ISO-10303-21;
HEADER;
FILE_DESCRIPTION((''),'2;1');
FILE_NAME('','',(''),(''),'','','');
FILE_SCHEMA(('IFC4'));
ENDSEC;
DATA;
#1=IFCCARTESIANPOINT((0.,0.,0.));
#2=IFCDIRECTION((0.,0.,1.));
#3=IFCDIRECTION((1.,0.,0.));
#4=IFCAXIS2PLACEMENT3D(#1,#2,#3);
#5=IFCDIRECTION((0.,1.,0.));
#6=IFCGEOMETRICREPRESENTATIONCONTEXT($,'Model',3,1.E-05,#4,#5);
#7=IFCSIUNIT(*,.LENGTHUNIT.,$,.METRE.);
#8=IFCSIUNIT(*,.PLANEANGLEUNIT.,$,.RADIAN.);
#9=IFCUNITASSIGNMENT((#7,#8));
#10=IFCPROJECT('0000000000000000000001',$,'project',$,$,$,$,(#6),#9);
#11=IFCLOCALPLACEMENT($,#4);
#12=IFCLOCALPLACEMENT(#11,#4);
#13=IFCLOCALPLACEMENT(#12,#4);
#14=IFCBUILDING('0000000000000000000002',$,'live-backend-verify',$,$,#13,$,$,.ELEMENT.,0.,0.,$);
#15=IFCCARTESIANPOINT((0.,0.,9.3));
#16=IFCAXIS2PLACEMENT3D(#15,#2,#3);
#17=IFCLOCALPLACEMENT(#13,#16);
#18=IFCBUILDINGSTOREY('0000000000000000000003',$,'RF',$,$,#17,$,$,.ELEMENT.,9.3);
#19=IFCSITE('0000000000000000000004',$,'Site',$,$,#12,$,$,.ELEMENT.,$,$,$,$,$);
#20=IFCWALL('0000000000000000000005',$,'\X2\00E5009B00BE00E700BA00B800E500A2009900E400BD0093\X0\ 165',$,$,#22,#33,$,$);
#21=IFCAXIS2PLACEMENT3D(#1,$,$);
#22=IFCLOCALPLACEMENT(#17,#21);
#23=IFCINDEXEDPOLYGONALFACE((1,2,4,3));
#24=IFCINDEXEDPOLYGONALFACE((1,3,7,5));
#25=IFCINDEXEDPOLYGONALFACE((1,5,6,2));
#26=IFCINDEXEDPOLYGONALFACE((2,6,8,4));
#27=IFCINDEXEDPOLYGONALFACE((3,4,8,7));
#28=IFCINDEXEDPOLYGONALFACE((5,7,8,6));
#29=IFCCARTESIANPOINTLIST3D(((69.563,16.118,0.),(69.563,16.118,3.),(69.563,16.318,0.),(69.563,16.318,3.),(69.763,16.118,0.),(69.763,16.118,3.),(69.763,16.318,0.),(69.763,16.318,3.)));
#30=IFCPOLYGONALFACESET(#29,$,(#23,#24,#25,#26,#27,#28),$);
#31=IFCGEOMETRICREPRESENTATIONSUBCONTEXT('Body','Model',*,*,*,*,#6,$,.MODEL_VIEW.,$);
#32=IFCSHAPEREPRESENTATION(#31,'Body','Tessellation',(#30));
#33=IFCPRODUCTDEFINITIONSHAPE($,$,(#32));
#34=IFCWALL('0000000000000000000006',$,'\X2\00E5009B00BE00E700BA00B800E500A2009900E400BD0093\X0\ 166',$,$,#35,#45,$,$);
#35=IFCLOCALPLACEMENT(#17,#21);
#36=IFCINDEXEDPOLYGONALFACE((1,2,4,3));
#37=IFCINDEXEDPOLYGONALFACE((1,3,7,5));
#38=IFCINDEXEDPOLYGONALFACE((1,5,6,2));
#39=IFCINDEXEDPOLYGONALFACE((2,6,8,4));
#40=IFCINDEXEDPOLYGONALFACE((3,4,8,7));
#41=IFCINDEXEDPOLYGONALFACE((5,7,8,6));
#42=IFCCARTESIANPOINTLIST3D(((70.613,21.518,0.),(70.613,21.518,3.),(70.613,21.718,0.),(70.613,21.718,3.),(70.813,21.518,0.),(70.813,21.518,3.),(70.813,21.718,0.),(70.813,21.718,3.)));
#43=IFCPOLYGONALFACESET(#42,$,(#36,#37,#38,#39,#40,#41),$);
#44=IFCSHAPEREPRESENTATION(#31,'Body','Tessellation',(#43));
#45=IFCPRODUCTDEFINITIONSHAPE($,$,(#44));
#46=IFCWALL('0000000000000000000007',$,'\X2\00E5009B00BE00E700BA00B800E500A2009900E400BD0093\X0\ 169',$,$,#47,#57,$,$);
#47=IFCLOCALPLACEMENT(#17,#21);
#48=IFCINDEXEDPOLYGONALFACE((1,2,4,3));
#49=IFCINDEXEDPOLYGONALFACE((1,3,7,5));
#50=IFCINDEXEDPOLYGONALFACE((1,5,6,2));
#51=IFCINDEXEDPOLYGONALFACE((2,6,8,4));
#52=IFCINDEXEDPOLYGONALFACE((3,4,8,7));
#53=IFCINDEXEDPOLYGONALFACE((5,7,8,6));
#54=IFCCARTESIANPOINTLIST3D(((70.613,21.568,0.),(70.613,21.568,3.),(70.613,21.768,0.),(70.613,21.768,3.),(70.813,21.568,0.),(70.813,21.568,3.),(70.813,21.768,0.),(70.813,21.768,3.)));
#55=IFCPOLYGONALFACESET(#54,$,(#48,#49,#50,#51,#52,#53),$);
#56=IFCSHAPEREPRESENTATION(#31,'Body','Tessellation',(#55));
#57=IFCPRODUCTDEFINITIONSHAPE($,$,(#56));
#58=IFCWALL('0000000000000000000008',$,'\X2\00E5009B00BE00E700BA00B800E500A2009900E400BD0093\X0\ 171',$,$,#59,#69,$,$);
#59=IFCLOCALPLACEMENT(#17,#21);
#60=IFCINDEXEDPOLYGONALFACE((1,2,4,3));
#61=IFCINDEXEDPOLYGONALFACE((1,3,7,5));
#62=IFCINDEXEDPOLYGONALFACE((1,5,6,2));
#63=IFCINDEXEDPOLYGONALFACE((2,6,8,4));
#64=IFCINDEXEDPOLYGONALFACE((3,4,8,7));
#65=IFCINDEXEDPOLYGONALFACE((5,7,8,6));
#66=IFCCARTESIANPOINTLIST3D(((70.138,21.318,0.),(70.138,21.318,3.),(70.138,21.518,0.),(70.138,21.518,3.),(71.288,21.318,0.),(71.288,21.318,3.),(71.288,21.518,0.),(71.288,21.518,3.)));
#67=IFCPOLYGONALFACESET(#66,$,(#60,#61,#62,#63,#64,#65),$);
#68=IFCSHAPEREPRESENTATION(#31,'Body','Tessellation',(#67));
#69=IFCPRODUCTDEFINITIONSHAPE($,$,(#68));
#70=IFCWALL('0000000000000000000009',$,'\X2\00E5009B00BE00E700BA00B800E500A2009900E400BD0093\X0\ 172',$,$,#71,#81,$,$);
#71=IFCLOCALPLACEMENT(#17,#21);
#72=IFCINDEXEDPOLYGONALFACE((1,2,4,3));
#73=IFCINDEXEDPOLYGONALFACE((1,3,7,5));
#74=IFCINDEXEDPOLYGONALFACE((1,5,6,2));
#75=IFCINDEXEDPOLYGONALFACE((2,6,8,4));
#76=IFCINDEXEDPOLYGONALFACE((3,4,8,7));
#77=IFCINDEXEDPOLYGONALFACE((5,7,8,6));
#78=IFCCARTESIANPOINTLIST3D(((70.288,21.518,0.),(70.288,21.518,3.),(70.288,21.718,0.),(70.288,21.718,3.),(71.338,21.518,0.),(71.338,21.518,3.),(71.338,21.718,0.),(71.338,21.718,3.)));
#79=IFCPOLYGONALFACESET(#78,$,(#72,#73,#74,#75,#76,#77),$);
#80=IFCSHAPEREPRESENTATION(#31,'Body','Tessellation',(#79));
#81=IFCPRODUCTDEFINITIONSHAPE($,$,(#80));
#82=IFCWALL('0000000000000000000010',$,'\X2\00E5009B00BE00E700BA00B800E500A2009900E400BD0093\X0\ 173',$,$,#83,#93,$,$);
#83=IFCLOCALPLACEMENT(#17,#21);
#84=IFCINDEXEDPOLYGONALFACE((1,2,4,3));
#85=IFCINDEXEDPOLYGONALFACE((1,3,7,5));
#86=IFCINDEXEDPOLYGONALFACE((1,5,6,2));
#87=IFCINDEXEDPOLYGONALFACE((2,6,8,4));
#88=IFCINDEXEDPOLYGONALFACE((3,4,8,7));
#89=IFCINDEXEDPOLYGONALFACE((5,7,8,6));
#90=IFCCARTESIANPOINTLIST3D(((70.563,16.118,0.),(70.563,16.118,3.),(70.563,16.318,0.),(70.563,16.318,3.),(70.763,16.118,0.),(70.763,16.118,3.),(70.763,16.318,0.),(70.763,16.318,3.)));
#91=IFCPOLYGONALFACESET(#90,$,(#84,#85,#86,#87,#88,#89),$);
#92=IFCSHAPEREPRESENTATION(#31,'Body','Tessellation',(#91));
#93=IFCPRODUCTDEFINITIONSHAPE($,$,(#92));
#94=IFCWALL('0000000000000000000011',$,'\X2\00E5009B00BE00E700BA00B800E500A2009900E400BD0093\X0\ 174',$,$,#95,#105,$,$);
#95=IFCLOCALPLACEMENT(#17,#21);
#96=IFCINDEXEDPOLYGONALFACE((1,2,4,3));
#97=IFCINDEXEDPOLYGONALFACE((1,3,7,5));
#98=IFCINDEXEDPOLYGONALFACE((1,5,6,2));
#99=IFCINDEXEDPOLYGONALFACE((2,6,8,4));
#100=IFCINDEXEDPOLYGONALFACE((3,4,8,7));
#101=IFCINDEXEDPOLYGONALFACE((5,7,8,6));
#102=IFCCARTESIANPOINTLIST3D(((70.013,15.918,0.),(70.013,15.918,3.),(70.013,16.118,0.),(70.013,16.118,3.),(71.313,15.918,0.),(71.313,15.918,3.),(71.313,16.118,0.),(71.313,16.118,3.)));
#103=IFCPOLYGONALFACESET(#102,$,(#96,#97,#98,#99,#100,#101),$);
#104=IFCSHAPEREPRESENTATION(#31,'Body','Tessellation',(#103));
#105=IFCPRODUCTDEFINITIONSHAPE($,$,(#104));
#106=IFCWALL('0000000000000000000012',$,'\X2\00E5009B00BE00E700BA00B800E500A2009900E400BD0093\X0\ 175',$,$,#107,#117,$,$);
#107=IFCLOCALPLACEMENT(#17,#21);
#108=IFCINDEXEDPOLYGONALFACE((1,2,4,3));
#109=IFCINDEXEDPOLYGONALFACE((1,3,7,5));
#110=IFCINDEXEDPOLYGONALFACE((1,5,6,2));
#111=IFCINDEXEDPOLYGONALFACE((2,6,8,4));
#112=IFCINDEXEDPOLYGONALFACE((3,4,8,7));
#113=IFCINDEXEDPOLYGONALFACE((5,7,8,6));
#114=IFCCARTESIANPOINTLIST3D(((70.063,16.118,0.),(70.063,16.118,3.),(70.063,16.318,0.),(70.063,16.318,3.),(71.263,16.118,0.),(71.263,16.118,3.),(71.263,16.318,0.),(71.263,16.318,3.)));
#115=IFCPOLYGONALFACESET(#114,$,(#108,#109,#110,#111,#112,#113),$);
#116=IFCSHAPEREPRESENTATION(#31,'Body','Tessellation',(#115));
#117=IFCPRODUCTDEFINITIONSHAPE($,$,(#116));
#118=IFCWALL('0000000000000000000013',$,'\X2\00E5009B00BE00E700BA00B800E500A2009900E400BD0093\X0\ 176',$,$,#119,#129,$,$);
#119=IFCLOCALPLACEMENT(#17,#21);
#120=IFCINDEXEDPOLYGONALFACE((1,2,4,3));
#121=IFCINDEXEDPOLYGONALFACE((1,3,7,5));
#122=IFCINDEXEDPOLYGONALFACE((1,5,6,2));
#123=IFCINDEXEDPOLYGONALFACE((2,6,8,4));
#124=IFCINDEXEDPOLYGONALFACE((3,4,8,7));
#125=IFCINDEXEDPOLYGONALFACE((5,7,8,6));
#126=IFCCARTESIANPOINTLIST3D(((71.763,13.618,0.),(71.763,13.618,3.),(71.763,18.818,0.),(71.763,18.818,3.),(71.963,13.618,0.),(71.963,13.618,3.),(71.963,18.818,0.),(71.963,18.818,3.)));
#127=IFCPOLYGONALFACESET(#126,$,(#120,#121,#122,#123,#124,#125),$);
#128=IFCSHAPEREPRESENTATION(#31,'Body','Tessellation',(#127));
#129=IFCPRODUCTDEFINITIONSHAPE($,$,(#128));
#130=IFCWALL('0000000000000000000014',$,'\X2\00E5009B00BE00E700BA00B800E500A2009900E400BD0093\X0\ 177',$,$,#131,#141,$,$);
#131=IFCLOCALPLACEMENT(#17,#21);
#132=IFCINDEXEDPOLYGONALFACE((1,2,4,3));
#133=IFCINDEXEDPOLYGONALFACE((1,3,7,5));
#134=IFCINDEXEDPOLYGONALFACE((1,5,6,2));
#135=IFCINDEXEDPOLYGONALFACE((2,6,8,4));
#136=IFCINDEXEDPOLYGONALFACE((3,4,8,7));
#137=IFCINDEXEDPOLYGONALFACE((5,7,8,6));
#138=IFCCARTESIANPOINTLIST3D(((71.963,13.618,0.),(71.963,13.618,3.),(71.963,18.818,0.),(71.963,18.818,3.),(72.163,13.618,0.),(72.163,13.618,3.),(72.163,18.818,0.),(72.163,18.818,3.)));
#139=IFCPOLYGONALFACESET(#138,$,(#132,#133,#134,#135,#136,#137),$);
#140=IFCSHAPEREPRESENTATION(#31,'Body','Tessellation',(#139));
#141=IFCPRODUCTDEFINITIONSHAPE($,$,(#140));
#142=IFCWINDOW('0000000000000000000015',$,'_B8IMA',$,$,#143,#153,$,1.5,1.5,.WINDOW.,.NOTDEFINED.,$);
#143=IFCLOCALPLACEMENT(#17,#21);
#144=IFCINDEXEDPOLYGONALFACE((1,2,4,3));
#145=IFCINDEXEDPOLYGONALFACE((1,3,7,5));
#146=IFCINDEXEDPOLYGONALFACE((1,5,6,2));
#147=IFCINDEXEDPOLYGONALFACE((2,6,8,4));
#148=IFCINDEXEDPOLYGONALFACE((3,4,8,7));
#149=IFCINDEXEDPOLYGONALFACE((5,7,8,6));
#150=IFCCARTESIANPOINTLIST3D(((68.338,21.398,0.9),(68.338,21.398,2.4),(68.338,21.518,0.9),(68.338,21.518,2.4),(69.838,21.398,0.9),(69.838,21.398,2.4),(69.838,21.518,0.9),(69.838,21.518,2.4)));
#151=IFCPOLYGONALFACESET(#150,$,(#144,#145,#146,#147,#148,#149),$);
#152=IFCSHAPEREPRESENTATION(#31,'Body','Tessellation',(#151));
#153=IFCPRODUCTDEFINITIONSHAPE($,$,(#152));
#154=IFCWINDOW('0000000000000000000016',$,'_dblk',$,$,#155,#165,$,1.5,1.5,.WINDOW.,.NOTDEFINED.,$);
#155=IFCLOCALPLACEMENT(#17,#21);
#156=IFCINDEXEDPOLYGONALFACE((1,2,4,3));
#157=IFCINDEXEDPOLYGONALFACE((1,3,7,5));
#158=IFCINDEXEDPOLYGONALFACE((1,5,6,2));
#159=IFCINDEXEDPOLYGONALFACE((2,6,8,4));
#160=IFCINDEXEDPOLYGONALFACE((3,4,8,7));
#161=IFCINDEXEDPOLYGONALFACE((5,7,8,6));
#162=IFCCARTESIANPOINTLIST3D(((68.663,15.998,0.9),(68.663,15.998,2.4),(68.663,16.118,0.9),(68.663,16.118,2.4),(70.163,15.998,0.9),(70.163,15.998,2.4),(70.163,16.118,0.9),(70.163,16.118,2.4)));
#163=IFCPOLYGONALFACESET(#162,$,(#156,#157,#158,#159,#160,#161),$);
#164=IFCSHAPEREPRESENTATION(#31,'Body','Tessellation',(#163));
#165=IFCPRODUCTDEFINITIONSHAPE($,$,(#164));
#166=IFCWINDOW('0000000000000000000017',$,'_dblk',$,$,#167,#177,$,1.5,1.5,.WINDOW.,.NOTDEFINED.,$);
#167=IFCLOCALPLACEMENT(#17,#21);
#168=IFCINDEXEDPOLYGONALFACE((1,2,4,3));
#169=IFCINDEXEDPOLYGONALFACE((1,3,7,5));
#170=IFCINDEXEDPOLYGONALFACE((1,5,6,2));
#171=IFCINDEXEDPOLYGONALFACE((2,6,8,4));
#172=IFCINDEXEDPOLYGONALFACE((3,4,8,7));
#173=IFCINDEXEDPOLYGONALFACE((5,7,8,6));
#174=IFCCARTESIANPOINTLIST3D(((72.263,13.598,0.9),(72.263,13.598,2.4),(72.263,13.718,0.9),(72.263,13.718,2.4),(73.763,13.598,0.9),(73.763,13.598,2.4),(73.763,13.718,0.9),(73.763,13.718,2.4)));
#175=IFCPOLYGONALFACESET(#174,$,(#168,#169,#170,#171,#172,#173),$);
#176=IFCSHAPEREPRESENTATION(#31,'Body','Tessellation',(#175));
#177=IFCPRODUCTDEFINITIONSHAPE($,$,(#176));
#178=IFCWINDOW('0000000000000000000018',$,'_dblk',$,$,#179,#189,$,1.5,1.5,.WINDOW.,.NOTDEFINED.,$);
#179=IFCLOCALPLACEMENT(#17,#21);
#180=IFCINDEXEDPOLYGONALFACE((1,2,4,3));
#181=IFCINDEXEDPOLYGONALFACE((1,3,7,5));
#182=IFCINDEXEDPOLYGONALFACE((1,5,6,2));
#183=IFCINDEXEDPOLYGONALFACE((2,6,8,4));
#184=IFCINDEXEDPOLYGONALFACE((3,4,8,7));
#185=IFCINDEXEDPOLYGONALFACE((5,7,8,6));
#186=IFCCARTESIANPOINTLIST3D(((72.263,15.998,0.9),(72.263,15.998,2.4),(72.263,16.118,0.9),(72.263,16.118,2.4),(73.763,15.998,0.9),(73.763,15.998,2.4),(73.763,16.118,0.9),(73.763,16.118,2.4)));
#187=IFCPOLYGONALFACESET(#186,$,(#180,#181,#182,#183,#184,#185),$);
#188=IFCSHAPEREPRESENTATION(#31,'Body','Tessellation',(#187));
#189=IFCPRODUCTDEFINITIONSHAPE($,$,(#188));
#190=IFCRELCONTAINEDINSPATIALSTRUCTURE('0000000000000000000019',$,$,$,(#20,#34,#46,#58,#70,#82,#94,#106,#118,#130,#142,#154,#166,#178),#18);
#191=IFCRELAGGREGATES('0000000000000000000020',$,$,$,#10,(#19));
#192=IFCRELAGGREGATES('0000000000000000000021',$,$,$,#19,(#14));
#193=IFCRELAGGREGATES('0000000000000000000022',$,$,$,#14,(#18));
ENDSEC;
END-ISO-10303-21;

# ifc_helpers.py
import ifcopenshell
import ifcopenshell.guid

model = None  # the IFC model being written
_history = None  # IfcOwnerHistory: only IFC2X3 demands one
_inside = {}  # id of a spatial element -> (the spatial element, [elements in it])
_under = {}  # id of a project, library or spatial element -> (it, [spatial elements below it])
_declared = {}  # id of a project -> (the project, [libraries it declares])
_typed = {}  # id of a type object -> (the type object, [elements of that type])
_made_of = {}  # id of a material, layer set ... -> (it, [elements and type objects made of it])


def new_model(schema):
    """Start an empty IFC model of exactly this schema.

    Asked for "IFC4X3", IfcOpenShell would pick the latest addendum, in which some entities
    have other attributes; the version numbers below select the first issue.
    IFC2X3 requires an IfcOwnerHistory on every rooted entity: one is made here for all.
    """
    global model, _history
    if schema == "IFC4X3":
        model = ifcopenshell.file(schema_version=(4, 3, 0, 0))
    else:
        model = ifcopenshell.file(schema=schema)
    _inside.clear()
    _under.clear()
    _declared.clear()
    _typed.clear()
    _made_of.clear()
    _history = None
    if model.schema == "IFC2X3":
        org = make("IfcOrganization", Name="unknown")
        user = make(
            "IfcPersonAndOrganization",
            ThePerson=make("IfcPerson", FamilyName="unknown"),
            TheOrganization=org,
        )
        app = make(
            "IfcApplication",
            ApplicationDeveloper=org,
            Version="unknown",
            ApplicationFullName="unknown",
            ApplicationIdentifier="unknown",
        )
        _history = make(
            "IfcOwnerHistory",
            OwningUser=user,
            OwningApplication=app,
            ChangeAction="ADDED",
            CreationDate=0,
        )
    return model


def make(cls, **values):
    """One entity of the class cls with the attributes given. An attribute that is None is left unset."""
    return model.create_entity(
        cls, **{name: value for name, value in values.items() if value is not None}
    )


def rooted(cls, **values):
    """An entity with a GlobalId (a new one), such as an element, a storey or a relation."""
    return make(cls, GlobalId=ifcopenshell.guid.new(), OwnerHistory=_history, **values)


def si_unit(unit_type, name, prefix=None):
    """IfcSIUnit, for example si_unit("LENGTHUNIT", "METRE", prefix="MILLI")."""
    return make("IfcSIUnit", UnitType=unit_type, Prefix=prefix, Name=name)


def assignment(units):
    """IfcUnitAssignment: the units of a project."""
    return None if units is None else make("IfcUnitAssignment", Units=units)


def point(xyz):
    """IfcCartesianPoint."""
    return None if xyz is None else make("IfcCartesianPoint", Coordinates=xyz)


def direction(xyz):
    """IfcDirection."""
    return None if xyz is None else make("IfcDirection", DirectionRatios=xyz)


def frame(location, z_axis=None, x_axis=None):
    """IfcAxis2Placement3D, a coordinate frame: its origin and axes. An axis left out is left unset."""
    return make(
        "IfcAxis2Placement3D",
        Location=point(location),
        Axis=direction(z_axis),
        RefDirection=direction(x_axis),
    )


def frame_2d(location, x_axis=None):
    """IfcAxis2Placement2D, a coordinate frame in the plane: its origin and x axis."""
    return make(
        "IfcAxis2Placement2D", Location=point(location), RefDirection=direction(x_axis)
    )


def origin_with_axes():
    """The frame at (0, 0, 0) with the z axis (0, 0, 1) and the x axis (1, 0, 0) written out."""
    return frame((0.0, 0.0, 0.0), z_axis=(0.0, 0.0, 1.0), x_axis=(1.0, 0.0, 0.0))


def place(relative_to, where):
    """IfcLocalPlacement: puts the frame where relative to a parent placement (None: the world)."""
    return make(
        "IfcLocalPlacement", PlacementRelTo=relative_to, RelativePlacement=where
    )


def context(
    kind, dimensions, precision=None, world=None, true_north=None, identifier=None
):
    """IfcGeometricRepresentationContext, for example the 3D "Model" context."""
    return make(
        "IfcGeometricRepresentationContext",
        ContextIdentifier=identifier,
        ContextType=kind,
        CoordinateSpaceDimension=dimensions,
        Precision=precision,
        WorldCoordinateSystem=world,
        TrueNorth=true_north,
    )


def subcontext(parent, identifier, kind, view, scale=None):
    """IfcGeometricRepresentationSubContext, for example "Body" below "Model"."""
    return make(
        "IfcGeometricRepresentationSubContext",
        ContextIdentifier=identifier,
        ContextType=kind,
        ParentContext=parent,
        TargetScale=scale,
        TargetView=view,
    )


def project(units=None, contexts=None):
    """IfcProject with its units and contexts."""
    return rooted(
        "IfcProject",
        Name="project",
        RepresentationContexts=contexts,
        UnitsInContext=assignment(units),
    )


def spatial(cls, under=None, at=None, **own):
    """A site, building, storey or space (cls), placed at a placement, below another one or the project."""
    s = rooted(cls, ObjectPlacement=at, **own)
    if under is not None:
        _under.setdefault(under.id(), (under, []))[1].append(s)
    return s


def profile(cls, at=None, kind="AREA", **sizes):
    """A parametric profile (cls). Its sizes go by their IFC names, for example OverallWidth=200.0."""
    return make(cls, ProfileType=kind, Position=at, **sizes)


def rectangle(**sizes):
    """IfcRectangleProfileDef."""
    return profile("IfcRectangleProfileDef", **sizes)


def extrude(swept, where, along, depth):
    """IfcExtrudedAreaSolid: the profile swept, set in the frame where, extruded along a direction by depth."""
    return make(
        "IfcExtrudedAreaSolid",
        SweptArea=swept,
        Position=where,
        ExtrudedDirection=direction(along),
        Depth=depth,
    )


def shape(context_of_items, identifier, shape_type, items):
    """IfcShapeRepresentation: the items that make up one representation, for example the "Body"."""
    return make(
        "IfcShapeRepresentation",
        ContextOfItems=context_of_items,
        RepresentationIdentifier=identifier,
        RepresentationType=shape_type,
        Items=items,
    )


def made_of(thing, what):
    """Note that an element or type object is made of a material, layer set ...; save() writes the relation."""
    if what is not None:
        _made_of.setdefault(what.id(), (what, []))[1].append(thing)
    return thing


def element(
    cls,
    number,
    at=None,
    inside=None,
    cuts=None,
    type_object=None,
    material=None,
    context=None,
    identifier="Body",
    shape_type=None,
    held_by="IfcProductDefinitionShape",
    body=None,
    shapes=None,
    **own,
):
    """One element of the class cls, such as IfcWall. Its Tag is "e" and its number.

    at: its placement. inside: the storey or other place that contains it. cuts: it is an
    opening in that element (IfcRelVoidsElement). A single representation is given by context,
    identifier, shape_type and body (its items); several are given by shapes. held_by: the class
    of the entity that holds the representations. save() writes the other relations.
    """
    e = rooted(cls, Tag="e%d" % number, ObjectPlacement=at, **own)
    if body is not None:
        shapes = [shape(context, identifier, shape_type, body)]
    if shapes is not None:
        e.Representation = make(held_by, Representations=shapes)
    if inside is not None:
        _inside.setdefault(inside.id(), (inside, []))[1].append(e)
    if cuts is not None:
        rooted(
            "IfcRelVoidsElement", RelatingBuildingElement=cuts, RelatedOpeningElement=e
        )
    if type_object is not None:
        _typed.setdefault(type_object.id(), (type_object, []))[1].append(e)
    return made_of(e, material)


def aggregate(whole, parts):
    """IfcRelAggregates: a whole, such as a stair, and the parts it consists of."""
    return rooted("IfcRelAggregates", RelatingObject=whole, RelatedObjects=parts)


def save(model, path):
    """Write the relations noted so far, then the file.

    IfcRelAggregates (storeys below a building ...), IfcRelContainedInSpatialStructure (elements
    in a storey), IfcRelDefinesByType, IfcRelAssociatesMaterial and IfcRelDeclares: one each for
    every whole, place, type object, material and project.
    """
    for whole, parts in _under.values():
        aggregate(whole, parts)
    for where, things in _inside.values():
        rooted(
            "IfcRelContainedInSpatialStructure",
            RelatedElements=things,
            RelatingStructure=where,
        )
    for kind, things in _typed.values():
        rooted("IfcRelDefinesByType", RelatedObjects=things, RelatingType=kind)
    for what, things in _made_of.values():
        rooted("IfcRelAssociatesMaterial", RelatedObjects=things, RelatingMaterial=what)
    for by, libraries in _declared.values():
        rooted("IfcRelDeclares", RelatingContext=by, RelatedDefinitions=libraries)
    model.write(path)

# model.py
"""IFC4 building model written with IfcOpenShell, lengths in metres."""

from ifc_helpers import new_model, si_unit, direction, frame, frame_2d, origin_with_axes, place, context, subcontext, project, spatial, rectangle, extrude, element, save


model = new_model("IFC4")

# Units and contexts
model_context = context("Model", 3, precision=1e-05, world=origin_with_axes(), true_north=direction((0.0, 1.0, 0.0)))
body_context = subcontext(model_context, "Body", "Model", "MODEL_VIEW")
ifc_project = project(units=[si_unit("LENGTHUNIT", "METRE"), si_unit("PLANEANGLEUNIT", "RADIAN")], contexts=[model_context])

# Site, building, storey
placement = place(None, origin_with_axes())
site_placement = place(placement, origin_with_axes())
site = spatial("IfcSite", under=ifc_project, at=site_placement, Name="Site", CompositionType="ELEMENT")
building_placement = place(site_placement, origin_with_axes())
building = spatial("IfcBuilding", under=site, at=building_placement, Name="live-backend-verify", CompositionType="ELEMENT", ElevationOfRefHeight=0.0, ElevationOfTerrain=0.0)
storey_placement = place(building_placement, frame((0.0, 0.0, 9.3), z_axis=(0.0, 0.0, 1.0), x_axis=(1.0, 0.0, 0.0)))
storey = spatial("IfcBuildingStorey", under=building, at=storey_placement, Name="RF", CompositionType="ELEMENT", Elevation=9.3)

# Walls
for number, where, z_axis, x_axis, name in (
    (1, (69.663, 16.218, 0.0), (0.0, 0.0, 1.0), (0.0, -1.0, 0.0), "å\u009b¾çº¸å¢\u0099ä½\u0093 165"),
    (2, (70.713, 21.618, 0.0), (0.0, 0.0, 1.0), (0.0, -1.0, 0.0), "å\u009b¾çº¸å¢\u0099ä½\u0093 166"),
    (3, (70.713, 21.668, 0.0), (0.0, 0.0, 1.0), (0.0, -1.0, 0.0), "å\u009b¾çº¸å¢\u0099ä½\u0093 169"),
):
    element("IfcWall", number, at=place(storey_placement, frame(where, z_axis=z_axis, x_axis=x_axis)), inside=storey, Name=name, context=body_context, shape_type="SweptSolid", body=[
        extrude(rectangle(XDim=0.2, YDim=0.2, at=frame_2d((0.0, 0.0), x_axis=(1.0, 0.0, 0.0))), frame((0.0, 0.0, 0.0), z_axis=(0.0, 0.0, 1.0)), (0.0, 0.0, 1.0), 3.0),
    ])
wall_1_placement = place(storey_placement, frame((70.713, 21.418, 0.0), z_axis=(0.0, 0.0, 1.0), x_axis=(1.0, 0.0, 0.0)))
element("IfcWall", 4, at=wall_1_placement, inside=storey, Name="å\u009b¾çº¸å¢\u0099ä½\u0093 171", context=body_context, shape_type="SweptSolid", body=[
    extrude(rectangle(XDim=1.15, YDim=0.2, at=frame_2d((0.0, 0.0), x_axis=(1.0, 0.0, 0.0))), frame((0.0, 0.0, 0.0), z_axis=(0.0, 0.0, 1.0)), (0.0, 0.0, 1.0), 3.0),
])
wall_2_placement = place(storey_placement, frame((70.813, 21.618, 0.0), z_axis=(0.0, 0.0, 1.0), x_axis=(1.0, 0.0, 0.0)))
element("IfcWall", 5, at=wall_2_placement, inside=storey, Name="å\u009b¾çº¸å¢\u0099ä½\u0093 172", context=body_context, shape_type="SweptSolid", body=[
    extrude(rectangle(XDim=1.05, YDim=0.2, at=frame_2d((0.0, 0.0), x_axis=(1.0, 0.0, 0.0))), frame((0.0, 0.0, 0.0), z_axis=(0.0, 0.0, 1.0)), (0.0, 0.0, 1.0), 3.0),
])
wall_3_placement = place(storey_placement, frame((70.663, 16.218, 0.0), z_axis=(0.0, 0.0, 1.0), x_axis=(0.0, -1.0, 0.0)))
element("IfcWall", 6, at=wall_3_placement, inside=storey, Name="å\u009b¾çº¸å¢\u0099ä½\u0093 173", context=body_context, shape_type="SweptSolid", body=[
    extrude(rectangle(XDim=0.2, YDim=0.2, at=frame_2d((0.0, 0.0), x_axis=(1.0, 0.0, 0.0))), frame((0.0, 0.0, 0.0), z_axis=(0.0, 0.0, 1.0)), (0.0, 0.0, 1.0), 3.0),
])
wall_4_placement = place(storey_placement, frame((70.663, 16.018, 0.0), z_axis=(0.0, 0.0, 1.0), x_axis=(1.0, 0.0, 0.0)))
element("IfcWall", 7, at=wall_4_placement, inside=storey, Name="å\u009b¾çº¸å¢\u0099ä½\u0093 174", context=body_context, shape_type="SweptSolid", body=[
    extrude(rectangle(XDim=1.3, YDim=0.2, at=frame_2d((0.0, 0.0), x_axis=(1.0, 0.0, 0.0))), frame((0.0, 0.0, 0.0), z_axis=(0.0, 0.0, 1.0)), (0.0, 0.0, 1.0), 3.0),
])
wall_5_placement = place(storey_placement, frame((70.663, 16.218, 0.0), z_axis=(0.0, 0.0, 1.0), x_axis=(1.0, 0.0, 0.0)))
element("IfcWall", 8, at=wall_5_placement, inside=storey, Name="å\u009b¾çº¸å¢\u0099ä½\u0093 175", context=body_context, shape_type="SweptSolid", body=[
    extrude(rectangle(XDim=1.2, YDim=0.2, at=frame_2d((0.0, 0.0), x_axis=(1.0, 0.0, 0.0))), frame((0.0, 0.0, 0.0), z_axis=(0.0, 0.0, 1.0)), (0.0, 0.0, 1.0), 3.0),
])
for number, where, z_axis, x_axis, name in (
    (9, (71.863, 16.218, 0.0), (0.0, 0.0, 1.0), (0.0, 1.0, 0.0), "å\u009b¾çº¸å¢\u0099ä½\u0093 176"),
    (10, (72.063, 16.218, 0.0), (0.0, 0.0, 1.0), (0.0, 1.0, 0.0), "å\u009b¾çº¸å¢\u0099ä½\u0093 177"),
):
    element("IfcWall", number, at=place(storey_placement, frame(where, z_axis=z_axis, x_axis=x_axis)), inside=storey, Name=name, context=body_context, shape_type="SweptSolid", body=[
        extrude(rectangle(XDim=5.2, YDim=0.2, at=frame_2d((0.0, 0.0), x_axis=(1.0, 0.0, 0.0))), frame((0.0, 0.0, 0.0), z_axis=(0.0, 0.0, 1.0)), (0.0, 0.0, 1.0), 3.0),
    ])

# Windows
for number, where, z_axis, x_axis, name in (
    (11, (69.088, 21.458, 0.9), (0.0, 0.0, 1.0), (1.0, 0.0, 0.0), "_B8IMA"),
    (12, (69.413, 16.058, 0.9), (0.0, 0.0, 1.0), (1.0, 0.0, 0.0), "_dblk"),
    (13, (73.013, 13.658, 0.9), (0.0, 0.0, 1.0), (1.0, 0.0, 0.0), "_dblk"),
    (14, (73.013, 16.058, 0.9), (0.0, 0.0, 1.0), (1.0, 0.0, 0.0), "_dblk"),
):
    element("IfcWindow", number, at=place(storey_placement, frame(where, z_axis=z_axis, x_axis=x_axis)), inside=storey, Name=name, OverallHeight=1.5, OverallWidth=1.5, PartitioningType="NOTDEFINED", PredefinedType="WINDOW", context=body_context, shape_type="SweptSolid", body=[
        extrude(rectangle(XDim=1.5, YDim=0.12, at=frame_2d((0.0, 0.0), x_axis=(1.0, 0.0, 0.0))), frame((0.0, 0.0, 0.0), z_axis=(0.0, 0.0, 1.0)), (0.0, 0.0, 1.0), 1.5),
    ])

save(model, "model.ifc")
